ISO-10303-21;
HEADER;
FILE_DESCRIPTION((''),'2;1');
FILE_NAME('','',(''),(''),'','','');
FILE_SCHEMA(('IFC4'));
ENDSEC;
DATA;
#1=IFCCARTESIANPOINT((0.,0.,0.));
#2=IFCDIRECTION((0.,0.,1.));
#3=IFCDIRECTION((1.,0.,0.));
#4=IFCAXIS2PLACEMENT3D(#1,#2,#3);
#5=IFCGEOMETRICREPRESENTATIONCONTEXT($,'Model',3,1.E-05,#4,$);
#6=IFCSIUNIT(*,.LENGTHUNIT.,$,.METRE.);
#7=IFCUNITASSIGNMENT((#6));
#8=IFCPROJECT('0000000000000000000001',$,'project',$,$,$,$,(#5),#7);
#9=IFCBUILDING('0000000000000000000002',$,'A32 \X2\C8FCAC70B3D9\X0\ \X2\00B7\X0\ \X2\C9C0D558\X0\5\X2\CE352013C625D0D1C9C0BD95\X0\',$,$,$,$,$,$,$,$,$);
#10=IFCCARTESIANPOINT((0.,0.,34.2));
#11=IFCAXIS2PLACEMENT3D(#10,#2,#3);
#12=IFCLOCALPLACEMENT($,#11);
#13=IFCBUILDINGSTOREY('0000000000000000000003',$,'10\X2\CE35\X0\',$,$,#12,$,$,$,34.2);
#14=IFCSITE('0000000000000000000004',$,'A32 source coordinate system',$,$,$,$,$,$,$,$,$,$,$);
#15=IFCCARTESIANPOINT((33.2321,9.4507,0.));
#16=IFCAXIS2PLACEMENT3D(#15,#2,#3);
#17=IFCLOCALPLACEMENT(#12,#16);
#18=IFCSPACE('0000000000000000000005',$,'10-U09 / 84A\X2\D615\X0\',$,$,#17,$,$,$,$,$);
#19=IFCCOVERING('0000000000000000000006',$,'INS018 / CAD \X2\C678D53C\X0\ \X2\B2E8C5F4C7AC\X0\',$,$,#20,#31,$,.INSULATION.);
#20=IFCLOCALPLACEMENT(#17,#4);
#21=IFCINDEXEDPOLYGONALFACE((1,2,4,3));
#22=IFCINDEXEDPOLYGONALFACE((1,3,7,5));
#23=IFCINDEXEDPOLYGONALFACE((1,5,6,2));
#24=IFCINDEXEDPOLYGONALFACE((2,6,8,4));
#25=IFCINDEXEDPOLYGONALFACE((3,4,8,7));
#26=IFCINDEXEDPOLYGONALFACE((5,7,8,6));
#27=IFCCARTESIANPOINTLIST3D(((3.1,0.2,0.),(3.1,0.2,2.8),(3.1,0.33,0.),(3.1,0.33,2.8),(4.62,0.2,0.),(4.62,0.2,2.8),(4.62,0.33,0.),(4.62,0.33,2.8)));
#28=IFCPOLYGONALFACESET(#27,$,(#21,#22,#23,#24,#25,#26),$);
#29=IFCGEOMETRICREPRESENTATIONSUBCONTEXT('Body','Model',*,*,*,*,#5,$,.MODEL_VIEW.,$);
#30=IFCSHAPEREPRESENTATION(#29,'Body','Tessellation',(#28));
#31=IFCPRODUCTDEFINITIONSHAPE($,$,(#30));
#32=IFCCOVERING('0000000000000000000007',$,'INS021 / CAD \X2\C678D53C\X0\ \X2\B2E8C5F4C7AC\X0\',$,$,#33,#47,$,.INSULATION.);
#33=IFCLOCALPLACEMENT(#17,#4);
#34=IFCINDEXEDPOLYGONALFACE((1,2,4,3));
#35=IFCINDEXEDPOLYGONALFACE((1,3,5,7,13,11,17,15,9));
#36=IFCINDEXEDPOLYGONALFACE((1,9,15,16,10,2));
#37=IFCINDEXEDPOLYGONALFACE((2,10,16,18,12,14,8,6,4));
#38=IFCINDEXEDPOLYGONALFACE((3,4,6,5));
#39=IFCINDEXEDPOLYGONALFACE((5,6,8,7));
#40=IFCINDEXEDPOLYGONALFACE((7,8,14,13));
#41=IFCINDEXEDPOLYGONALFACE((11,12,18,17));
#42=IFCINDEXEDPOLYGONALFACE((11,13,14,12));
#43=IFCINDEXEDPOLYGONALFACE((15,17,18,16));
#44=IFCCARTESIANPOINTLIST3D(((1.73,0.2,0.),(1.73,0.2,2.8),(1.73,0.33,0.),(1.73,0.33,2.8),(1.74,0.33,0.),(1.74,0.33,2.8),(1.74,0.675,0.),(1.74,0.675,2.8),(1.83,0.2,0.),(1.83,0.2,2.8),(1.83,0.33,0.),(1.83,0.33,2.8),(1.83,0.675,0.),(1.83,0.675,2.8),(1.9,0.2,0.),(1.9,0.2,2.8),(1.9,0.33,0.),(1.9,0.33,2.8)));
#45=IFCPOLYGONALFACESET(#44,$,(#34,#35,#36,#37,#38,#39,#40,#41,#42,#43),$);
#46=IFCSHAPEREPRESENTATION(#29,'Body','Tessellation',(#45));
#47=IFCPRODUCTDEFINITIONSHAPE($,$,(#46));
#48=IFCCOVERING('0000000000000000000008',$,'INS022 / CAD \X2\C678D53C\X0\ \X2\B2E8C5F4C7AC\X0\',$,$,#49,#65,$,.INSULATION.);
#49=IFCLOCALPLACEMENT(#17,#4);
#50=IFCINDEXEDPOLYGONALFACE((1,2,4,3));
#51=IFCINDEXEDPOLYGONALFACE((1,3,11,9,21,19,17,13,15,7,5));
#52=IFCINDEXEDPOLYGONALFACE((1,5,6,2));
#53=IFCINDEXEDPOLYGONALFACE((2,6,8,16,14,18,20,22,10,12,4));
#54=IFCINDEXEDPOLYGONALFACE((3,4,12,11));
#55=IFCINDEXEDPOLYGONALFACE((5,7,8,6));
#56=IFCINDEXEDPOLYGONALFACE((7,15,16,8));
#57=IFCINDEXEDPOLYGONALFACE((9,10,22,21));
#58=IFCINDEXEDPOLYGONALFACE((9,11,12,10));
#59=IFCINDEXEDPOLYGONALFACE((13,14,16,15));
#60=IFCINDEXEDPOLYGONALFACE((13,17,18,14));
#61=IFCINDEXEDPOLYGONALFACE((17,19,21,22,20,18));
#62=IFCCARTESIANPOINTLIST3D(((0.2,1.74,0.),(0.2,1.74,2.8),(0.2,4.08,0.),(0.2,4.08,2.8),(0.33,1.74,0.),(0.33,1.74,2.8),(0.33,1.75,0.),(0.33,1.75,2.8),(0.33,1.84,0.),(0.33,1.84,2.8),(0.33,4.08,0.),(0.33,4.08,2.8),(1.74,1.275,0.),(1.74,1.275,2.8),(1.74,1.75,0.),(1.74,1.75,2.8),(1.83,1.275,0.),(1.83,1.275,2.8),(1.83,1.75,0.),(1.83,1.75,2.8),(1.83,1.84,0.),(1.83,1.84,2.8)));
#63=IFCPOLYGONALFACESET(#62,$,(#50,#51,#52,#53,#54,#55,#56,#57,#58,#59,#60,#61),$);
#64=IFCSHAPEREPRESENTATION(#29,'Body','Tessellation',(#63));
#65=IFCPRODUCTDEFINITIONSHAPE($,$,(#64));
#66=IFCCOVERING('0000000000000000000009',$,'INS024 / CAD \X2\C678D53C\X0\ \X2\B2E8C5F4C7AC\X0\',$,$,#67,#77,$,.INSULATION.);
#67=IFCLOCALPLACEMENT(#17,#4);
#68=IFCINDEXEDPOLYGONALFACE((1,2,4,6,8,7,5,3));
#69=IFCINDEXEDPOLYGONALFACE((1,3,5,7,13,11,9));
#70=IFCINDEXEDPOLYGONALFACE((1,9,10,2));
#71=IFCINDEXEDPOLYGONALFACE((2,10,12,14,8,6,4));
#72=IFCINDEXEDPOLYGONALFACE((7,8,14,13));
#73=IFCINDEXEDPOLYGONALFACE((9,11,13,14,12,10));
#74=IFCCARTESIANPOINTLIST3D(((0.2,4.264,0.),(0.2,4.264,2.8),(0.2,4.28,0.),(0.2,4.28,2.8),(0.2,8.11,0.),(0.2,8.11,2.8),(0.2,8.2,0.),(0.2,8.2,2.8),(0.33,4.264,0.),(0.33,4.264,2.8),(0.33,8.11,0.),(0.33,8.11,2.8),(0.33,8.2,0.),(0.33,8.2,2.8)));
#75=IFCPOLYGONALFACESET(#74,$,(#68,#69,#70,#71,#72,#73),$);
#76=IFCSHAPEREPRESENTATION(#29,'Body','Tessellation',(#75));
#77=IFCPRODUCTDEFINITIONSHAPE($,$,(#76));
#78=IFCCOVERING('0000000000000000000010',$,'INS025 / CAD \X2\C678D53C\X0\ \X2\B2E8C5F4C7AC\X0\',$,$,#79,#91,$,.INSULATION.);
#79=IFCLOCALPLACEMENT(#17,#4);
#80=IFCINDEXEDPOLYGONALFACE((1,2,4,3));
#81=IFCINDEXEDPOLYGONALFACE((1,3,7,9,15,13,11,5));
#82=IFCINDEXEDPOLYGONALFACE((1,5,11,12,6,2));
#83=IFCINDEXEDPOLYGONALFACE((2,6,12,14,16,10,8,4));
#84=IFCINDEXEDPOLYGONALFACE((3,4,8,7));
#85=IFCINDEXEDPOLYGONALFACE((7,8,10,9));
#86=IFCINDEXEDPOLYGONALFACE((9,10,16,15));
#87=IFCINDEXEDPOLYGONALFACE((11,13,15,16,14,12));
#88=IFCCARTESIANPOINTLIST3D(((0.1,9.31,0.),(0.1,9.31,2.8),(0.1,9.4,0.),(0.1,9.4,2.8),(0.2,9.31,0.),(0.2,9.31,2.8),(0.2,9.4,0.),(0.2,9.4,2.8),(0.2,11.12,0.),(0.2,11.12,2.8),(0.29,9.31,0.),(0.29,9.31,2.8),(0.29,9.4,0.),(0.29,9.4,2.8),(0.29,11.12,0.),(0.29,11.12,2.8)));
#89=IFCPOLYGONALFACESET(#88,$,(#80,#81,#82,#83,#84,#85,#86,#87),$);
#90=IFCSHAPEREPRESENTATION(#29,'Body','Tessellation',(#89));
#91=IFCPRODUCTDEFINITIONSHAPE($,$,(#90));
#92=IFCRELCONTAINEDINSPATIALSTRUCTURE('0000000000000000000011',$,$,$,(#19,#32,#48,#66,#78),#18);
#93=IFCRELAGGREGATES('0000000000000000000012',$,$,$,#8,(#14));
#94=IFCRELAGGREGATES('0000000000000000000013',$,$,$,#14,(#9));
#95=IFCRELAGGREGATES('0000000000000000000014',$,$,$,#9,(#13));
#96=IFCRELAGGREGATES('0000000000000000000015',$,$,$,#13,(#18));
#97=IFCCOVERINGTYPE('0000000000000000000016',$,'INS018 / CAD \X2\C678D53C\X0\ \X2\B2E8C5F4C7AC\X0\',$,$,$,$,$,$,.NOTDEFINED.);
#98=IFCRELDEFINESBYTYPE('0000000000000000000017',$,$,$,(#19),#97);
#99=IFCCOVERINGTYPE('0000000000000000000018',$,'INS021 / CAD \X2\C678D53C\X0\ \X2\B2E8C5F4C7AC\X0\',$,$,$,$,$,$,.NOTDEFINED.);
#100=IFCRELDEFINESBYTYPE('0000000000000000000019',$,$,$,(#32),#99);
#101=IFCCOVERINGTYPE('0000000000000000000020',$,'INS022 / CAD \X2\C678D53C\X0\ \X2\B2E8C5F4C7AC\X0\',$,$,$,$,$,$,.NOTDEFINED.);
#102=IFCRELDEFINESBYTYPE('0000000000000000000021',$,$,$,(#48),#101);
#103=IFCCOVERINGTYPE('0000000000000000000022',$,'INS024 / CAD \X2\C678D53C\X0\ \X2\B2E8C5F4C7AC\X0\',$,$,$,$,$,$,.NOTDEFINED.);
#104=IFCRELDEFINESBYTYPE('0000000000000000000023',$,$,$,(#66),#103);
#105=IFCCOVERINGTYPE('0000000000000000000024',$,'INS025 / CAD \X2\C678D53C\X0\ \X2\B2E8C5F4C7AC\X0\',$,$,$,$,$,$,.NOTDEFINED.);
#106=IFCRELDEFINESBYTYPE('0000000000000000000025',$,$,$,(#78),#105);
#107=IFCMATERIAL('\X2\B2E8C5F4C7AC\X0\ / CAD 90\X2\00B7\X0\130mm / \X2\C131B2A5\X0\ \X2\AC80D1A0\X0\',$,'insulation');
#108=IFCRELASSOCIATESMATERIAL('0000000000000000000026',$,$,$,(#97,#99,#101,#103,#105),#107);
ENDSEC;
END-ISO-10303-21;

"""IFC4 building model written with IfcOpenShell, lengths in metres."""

from ifc_helpers import new_model, si_unit, frame, origin, origin_with_axes, place, context, subcontext, project, spatial, polyline, outline, extrude, source, transform, mapped, material, type_object, type_shapes, element, save


model = new_model("IFC4")

# Units and contexts
model_context = context("Model", 3, precision=1e-05, world=origin_with_axes())
body_context = subcontext(model_context, "Body", "Model", "MODEL_VIEW")
ifc_project = project(units=[si_unit("LENGTHUNIT", "METRE")], contexts=[model_context])

# Site, building, storey, space
storey_placement = place(None, frame((0.0, 0.0, 34.2), z_axis=(0.0, 0.0, 1.0), x_axis=(1.0, 0.0, 0.0)))
space_placement = place(storey_placement, frame((33.2321, 9.4507, 0.0), z_axis=(0.0, 0.0, 1.0), x_axis=(1.0, 0.0, 0.0)))
site = spatial("IfcSite", under=ifc_project, Name="A32 source coordinate system")
building = spatial("IfcBuilding", under=site, Name="A32 주거동 · 지하5층–옥탑지붕")
storey = spatial("IfcBuildingStorey", under=building, at=storey_placement, Name="10층", Elevation=34.2)
space = spatial("IfcSpace", under=storey, at=space_placement, Name="10-U09 / 84A형")

# Coverings
ifc_material = material(Name="단열재 / CAD 90·130mm / 성능 검토", Category="insulation")
covering_type_1 = type_object("IfcCoveringType", Name="INS018 / CAD 외피 단열재", PredefinedType="NOTDEFINED", material=ifc_material)
shared_shape_1 = source(origin(), body_context, "Body", "SweptSolid", [
    extrude(outline(polyline([(3.1, 0.33), (4.62, 0.33), (4.62, 0.2), (3.1, 0.2), (3.1, 0.33)])), origin(), (0.0, 0.0, 1.0), 2.8),
])
type_shapes(covering_type_1, [shared_shape_1])
covering_1_placement = place(space_placement, origin_with_axes())
element("IfcCovering", 1, at=covering_1_placement, inside=space, type_object=covering_type_1, Name="INS018 / CAD 외피 단열재", PredefinedType="INSULATION", context=body_context, shape_type="MappedRepresentation", body=[
    mapped(shared_shape_1, transform((0.0, 0.0, 0.0), scale=1.0)),
])
covering_type_2 = type_object("IfcCoveringType", Name="INS021 / CAD 외피 단열재", PredefinedType="NOTDEFINED", material=ifc_material)
shared_shape_2 = source(origin(), body_context, "Body", "SweptSolid", [
    extrude(outline(polyline([(1.83, 0.33), (1.9, 0.33), (1.9, 0.2), (1.83, 0.2), (1.73, 0.2), (1.73, 0.33), (1.74, 0.33), (1.74, 0.675), (1.83, 0.675), (1.83, 0.33)])), origin(), (0.0, 0.0, 1.0), 2.8),
])
type_shapes(covering_type_2, [shared_shape_2])
covering_2_placement = place(space_placement, origin_with_axes())
element("IfcCovering", 2, at=covering_2_placement, inside=space, type_object=covering_type_2, Name="INS021 / CAD 외피 단열재", PredefinedType="INSULATION", context=body_context, shape_type="MappedRepresentation", body=[
    mapped(shared_shape_2, transform((0.0, 0.0, 0.0), scale=1.0)),
])
covering_type_3 = type_object("IfcCoveringType", Name="INS022 / CAD 외피 단열재", PredefinedType="NOTDEFINED", material=ifc_material)
shared_shape_3 = source(origin(), body_context, "Body", "SweptSolid", [
    extrude(outline(polyline([(1.83, 1.84), (1.83, 1.75), (1.83, 1.275), (1.74, 1.275), (1.74, 1.75), (0.33, 1.75), (0.33, 1.74), (0.2, 1.74), (0.2, 4.08), (0.33, 4.08), (0.33, 1.84), (1.83, 1.84)])), origin(), (0.0, 0.0, 1.0), 2.8),
])
type_shapes(covering_type_3, [shared_shape_3])
covering_3_placement = place(space_placement, origin_with_axes())
element("IfcCovering", 3, at=covering_3_placement, inside=space, type_object=covering_type_3, Name="INS022 / CAD 외피 단열재", PredefinedType="INSULATION", context=body_context, shape_type="MappedRepresentation", body=[
    mapped(shared_shape_3, transform((0.0, 0.0, 0.0), scale=1.0)),
])
covering_type_4 = type_object("IfcCoveringType", Name="INS024 / CAD 외피 단열재", PredefinedType="NOTDEFINED", material=ifc_material)
shared_shape_4 = source(origin(), body_context, "Body", "SweptSolid", [
    extrude(outline(polyline([(0.2, 8.11), (0.2, 8.2), (0.33, 8.2), (0.33, 8.11), (0.33, 4.264), (0.2, 4.264), (0.2, 4.28), (0.2, 8.11)])), origin(), (0.0, 0.0, 1.0), 2.8),
])
type_shapes(covering_type_4, [shared_shape_4])
covering_4_placement = place(space_placement, origin_with_axes())
element("IfcCovering", 4, at=covering_4_placement, inside=space, type_object=covering_type_4, Name="INS024 / CAD 외피 단열재", PredefinedType="INSULATION", context=body_context, shape_type="MappedRepresentation", body=[
    mapped(shared_shape_4, transform((0.0, 0.0, 0.0), scale=1.0)),
])
covering_type_5 = type_object("IfcCoveringType", Name="INS025 / CAD 외피 단열재", PredefinedType="NOTDEFINED", material=ifc_material)
shared_shape_5 = source(origin(), body_context, "Body", "SweptSolid", [
    extrude(outline(polyline([(0.2, 9.4), (0.2, 11.12), (0.29, 11.12), (0.29, 9.4), (0.29, 9.31), (0.2, 9.31), (0.1, 9.31), (0.1, 9.4), (0.2, 9.4)])), origin(), (0.0, 0.0, 1.0), 2.8),
])
type_shapes(covering_type_5, [shared_shape_5])
covering_5_placement = place(space_placement, origin_with_axes())
element("IfcCovering", 5, at=covering_5_placement, inside=space, type_object=covering_type_5, Name="INS025 / CAD 외피 단열재", PredefinedType="INSULATION", context=body_context, shape_type="MappedRepresentation", body=[
    mapped(shared_shape_5, transform((0.0, 0.0, 0.0), scale=1.0)),
])

save(model, "model.ifc")
